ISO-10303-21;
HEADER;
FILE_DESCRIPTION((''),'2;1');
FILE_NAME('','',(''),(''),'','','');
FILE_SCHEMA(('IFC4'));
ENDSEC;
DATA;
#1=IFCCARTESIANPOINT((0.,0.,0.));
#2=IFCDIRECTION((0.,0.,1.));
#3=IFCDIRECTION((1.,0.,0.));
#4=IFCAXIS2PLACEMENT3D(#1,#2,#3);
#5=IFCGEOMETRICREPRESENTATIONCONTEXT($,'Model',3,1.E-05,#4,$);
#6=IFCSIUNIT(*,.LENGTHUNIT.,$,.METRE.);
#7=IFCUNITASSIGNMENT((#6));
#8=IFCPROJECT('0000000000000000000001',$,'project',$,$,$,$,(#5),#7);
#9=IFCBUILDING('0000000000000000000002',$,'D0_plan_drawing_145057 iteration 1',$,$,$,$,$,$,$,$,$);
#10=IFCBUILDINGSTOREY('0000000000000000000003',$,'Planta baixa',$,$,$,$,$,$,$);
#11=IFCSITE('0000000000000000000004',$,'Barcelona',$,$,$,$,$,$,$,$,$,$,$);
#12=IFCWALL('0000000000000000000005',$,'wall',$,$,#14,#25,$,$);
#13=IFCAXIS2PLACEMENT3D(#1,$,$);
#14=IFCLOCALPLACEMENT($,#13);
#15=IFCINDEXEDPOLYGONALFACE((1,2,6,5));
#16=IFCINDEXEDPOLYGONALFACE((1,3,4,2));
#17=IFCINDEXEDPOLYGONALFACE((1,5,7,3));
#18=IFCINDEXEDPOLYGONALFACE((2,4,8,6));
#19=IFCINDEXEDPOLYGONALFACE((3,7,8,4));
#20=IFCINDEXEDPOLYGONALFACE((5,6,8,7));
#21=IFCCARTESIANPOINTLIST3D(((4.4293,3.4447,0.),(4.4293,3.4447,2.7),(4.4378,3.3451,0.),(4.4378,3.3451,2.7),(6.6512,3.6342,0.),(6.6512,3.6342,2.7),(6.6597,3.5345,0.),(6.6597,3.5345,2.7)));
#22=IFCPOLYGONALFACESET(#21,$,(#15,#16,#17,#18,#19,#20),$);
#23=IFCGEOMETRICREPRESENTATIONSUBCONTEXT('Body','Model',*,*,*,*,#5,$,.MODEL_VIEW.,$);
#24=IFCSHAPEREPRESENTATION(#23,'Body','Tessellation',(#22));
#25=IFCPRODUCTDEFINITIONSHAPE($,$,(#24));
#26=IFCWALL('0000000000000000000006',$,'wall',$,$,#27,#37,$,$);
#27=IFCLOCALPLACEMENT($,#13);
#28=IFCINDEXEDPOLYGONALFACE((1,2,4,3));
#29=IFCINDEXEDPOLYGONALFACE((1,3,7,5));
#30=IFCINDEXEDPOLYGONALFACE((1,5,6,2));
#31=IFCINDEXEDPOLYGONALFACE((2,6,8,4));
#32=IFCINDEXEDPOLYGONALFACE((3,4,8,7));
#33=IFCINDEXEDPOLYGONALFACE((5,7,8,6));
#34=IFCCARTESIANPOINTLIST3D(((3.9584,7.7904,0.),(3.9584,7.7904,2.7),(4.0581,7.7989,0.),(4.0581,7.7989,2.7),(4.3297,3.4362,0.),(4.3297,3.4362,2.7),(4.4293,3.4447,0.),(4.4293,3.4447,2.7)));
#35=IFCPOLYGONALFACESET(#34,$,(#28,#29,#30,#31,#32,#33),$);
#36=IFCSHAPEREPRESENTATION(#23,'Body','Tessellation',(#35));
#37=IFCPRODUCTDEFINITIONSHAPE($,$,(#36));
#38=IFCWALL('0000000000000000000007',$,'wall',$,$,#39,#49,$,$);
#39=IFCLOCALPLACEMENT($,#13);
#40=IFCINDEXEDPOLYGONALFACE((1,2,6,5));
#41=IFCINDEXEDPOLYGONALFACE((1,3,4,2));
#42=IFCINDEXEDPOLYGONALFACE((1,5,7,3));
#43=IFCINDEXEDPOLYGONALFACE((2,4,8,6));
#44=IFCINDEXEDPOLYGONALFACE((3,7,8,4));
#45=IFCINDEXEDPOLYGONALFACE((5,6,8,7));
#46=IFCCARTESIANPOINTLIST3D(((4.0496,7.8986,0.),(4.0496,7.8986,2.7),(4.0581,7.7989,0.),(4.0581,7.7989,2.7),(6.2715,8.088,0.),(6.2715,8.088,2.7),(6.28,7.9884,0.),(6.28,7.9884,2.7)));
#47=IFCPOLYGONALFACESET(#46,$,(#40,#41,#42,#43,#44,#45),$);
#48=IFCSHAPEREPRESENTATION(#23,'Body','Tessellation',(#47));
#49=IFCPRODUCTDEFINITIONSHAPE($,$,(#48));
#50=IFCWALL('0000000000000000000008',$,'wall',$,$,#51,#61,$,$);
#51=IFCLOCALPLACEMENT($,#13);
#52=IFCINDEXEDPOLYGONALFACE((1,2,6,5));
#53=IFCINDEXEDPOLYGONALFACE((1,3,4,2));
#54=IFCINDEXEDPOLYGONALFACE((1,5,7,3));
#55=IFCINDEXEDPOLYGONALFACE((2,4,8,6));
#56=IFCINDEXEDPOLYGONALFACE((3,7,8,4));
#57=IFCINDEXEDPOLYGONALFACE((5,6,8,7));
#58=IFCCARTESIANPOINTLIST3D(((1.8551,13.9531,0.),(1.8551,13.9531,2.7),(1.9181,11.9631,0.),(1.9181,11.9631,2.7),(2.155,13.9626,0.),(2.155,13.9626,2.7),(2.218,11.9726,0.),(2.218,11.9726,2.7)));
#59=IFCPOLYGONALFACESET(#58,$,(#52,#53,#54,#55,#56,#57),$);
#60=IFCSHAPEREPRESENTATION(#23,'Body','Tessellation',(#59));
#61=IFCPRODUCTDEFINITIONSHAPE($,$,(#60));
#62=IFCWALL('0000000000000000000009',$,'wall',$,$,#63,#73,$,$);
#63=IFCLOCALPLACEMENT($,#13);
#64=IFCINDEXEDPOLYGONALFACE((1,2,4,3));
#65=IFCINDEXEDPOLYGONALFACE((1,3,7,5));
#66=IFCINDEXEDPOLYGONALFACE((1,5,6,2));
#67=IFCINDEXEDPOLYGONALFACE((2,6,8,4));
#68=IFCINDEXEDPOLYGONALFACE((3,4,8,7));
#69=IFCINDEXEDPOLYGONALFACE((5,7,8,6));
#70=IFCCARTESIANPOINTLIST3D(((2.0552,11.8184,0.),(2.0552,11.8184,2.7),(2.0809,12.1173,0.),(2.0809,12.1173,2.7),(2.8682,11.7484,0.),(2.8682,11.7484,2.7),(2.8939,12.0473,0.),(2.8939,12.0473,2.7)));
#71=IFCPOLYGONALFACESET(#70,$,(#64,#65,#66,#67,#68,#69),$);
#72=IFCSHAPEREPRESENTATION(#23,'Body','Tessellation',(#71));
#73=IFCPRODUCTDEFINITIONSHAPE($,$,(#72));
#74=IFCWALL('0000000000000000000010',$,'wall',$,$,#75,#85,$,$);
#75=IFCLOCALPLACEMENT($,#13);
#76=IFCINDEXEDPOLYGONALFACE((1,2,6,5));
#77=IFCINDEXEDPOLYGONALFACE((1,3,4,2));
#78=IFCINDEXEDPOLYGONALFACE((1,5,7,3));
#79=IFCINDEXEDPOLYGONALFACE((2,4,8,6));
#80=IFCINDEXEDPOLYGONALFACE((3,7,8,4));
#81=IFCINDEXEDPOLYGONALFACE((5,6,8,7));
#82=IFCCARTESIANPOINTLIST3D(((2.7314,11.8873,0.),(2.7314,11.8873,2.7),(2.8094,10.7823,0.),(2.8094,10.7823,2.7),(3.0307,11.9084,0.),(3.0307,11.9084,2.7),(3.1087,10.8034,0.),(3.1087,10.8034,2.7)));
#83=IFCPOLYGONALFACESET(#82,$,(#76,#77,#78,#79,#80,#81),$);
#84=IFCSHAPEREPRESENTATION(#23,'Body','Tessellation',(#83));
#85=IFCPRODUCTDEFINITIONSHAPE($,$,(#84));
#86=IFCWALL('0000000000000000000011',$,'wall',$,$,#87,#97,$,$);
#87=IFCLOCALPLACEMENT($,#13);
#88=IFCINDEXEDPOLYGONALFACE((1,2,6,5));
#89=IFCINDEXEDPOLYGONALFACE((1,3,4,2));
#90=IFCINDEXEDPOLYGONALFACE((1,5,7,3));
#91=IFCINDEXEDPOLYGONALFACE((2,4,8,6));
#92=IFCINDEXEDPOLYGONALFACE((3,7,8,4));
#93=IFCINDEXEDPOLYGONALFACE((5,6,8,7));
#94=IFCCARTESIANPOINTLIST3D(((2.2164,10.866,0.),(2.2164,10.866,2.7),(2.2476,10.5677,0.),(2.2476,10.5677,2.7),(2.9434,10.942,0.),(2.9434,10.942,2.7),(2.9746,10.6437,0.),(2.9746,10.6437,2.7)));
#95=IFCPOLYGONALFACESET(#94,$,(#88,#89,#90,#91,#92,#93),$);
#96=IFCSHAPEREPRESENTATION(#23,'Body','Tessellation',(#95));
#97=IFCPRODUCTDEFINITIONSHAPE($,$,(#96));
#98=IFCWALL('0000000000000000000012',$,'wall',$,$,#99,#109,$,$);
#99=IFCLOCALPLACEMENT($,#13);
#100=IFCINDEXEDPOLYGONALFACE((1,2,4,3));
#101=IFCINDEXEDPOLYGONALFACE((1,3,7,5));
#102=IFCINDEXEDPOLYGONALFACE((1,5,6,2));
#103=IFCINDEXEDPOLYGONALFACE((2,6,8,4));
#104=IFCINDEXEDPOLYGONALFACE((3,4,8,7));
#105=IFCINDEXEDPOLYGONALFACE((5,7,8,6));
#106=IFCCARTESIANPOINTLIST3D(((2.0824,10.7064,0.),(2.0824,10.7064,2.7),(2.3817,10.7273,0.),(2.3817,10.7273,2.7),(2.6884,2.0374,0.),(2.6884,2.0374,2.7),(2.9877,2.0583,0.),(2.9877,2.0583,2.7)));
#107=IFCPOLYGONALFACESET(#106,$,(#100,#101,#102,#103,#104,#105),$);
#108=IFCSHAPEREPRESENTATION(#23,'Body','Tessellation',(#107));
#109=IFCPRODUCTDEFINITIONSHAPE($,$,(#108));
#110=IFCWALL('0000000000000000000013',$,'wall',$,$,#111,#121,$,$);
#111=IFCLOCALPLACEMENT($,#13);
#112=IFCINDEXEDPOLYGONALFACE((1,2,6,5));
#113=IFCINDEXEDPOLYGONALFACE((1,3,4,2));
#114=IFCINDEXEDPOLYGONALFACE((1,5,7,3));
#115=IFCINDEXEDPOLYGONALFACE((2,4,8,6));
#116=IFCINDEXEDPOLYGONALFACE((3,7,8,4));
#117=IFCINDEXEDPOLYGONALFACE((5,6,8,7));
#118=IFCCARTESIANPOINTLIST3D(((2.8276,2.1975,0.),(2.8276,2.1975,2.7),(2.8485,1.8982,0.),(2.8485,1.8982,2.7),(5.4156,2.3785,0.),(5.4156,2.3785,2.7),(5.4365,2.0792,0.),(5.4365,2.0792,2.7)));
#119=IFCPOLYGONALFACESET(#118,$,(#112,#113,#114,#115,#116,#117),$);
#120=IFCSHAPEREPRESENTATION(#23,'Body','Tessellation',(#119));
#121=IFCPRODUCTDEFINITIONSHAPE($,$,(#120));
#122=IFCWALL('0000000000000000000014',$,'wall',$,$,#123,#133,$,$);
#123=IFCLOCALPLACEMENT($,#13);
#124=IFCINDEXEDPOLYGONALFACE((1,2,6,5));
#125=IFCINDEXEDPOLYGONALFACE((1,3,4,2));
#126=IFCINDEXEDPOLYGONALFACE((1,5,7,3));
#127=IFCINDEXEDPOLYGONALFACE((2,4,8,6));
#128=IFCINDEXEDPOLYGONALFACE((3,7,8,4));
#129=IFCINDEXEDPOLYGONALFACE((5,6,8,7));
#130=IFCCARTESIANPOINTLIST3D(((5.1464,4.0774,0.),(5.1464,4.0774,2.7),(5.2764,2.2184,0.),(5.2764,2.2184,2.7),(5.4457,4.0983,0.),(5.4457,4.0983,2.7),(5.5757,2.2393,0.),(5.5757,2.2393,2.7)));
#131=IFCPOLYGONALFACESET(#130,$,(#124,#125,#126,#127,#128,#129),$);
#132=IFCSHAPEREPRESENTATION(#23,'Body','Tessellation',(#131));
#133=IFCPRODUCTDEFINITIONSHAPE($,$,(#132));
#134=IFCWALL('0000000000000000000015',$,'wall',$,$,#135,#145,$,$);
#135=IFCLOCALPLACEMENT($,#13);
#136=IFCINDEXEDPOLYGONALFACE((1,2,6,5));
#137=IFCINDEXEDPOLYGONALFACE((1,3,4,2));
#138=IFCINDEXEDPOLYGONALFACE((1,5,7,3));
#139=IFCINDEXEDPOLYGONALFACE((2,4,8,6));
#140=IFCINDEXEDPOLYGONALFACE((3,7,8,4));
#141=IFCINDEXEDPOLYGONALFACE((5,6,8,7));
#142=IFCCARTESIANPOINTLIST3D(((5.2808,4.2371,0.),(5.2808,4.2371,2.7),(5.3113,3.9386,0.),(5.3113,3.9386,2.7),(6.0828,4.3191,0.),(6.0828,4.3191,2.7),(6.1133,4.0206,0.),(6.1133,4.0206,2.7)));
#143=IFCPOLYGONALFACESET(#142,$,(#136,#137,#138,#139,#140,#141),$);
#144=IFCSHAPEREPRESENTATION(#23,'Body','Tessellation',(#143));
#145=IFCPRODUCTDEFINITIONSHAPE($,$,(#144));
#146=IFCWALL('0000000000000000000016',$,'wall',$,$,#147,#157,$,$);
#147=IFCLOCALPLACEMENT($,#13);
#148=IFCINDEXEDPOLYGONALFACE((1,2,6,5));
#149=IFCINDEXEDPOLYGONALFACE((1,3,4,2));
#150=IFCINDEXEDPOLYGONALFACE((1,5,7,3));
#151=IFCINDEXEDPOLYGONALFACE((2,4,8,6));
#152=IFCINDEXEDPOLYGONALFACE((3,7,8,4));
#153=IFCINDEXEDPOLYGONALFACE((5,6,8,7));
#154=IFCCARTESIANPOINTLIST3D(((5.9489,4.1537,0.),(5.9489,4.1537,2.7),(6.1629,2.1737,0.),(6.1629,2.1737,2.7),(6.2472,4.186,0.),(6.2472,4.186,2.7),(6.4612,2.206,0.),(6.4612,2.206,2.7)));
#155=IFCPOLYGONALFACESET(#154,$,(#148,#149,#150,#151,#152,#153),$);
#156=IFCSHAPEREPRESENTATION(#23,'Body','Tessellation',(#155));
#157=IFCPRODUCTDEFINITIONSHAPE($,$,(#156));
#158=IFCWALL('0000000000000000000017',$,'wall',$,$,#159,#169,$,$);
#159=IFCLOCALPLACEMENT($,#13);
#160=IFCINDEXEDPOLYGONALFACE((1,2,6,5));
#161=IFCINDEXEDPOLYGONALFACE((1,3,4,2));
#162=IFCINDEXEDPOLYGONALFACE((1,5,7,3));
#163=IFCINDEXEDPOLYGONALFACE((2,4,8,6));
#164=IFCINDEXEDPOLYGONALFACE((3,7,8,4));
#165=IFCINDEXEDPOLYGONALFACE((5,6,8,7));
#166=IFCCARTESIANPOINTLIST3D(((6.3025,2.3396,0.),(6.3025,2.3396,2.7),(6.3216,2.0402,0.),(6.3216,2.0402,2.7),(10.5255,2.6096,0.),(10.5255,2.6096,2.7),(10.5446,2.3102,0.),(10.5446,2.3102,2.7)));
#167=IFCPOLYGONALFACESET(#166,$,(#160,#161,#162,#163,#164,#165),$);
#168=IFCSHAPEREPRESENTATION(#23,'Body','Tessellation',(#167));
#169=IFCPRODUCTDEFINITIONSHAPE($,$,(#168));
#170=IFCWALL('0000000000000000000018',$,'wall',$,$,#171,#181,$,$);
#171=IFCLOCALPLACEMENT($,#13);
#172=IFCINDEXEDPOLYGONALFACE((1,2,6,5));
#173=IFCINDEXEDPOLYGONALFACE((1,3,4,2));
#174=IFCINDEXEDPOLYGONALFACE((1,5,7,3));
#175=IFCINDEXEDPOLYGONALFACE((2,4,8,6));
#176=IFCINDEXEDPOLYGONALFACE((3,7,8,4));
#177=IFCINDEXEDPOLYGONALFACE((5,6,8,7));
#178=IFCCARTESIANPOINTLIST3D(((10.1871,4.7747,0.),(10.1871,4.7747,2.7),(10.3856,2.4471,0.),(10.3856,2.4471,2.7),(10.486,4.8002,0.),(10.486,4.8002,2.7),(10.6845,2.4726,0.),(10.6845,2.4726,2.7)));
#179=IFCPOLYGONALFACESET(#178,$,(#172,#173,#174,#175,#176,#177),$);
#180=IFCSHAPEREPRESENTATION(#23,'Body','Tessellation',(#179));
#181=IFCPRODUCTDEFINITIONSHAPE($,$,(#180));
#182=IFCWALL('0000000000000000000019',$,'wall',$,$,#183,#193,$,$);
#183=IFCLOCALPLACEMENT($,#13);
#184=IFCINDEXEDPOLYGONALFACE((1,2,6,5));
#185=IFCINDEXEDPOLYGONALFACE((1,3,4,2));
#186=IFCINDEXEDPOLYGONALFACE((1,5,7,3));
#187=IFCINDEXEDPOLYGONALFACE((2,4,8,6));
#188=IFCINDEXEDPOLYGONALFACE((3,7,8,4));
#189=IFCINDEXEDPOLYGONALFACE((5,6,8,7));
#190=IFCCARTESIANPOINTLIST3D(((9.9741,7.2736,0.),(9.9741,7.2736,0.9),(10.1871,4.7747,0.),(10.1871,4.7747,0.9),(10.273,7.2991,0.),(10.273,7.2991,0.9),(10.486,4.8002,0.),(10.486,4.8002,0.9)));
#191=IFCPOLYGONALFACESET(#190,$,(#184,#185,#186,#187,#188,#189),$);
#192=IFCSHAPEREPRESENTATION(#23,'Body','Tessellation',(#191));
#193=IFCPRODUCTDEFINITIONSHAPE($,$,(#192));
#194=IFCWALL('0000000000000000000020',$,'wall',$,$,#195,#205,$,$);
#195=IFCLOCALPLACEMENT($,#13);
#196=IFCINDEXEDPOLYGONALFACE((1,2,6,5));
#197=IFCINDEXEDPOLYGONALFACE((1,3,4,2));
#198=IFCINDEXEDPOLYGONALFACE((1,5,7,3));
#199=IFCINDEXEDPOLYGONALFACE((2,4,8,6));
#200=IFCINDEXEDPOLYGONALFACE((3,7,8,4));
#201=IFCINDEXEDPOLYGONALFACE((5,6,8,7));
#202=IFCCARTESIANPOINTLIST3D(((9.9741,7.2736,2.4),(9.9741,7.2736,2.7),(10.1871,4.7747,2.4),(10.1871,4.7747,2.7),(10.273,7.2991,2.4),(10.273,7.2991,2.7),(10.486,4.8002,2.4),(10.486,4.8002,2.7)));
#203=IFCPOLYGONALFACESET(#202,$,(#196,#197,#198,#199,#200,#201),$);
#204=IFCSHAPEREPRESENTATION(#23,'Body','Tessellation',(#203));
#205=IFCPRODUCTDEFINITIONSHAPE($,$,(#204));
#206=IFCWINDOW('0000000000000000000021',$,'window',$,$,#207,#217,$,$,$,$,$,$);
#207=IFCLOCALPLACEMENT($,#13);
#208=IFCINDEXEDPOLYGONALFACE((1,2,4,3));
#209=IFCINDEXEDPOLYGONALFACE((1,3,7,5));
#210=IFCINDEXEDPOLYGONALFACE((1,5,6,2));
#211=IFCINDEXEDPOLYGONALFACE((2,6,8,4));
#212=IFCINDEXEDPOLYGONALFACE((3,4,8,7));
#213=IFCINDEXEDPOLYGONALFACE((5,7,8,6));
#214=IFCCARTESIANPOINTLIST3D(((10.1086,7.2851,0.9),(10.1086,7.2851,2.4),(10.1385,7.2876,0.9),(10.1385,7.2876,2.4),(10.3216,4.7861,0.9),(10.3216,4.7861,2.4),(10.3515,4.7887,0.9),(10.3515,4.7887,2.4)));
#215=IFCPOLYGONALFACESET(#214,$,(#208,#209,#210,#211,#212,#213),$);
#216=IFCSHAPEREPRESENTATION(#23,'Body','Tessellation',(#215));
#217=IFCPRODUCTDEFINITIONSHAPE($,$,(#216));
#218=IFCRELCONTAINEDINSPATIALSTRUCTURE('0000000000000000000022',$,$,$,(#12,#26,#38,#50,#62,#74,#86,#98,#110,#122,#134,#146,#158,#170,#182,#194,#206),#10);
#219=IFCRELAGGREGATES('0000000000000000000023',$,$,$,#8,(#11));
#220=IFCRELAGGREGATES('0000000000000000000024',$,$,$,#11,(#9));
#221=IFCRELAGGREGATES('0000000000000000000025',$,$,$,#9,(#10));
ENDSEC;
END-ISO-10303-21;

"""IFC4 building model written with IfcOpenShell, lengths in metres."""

from ifc_helpers import new_model, si_unit, frame, origin, origin_with_axes, place, context, subcontext, project, spatial, polyline, outline, extrude, element, save


model = new_model("IFC4")

# Units and contexts
model_context = context("Model", 3, precision=1e-05, world=origin_with_axes())
body_context = subcontext(model_context, "Body", "Model", "MODEL_VIEW")
ifc_project = project(units=[si_unit("LENGTHUNIT", "METRE")], contexts=[model_context])

# Site, building, storey
site = spatial("IfcSite", under=ifc_project, Name="Barcelona")
building = spatial("IfcBuilding", under=site, Name="D0_plan_drawing_145057 iteration 1")
storey = spatial("IfcBuildingStorey", under=building, Name="Planta baixa")

# Walls
wall_1_placement = place(None, origin_with_axes())
element("IfcWall", 1, at=wall_1_placement, inside=storey, Name="wall", context=body_context, shape_type="SweptSolid", body=[
    extrude(outline(polyline([(6.6597, 3.5345), (4.4378, 3.3451), (4.4293, 3.4447), (6.6512, 3.6342), (6.6597, 3.5345)])), origin(), (0.0, 0.0, 1.0), 2.7),
])
wall_2_placement = place(None, origin_with_axes())
element("IfcWall", 2, at=wall_2_placement, inside=storey, Name="wall", context=body_context, shape_type="SweptSolid", body=[
    extrude(outline(polyline([(4.3297, 3.4362), (3.9584, 7.7904), (4.0581, 7.7989), (4.4293, 3.4447), (4.3297, 3.4362)])), origin(), (0.0, 0.0, 1.0), 2.7),
])
wall_3_placement = place(None, origin_with_axes())
element("IfcWall", 3, at=wall_3_placement, inside=storey, Name="wall", context=body_context, shape_type="SweptSolid", body=[
    extrude(outline(polyline([(4.0496, 7.8986), (6.2715, 8.088), (6.28, 7.9884), (4.0581, 7.7989), (4.0496, 7.8986)])), origin(), (0.0, 0.0, 1.0), 2.7),
])
wall_4_placement = place(None, origin_with_axes())
element("IfcWall", 4, at=wall_4_placement, inside=storey, Name="wall", context=body_context, shape_type="SweptSolid", body=[
    extrude(outline(polyline([(2.155, 13.9626), (2.218, 11.9726), (1.9181, 11.9631), (1.8551, 13.9531), (2.155, 13.9626)])), origin(), (0.0, 0.0, 1.0), 2.7),
])
wall_5_placement = place(None, origin_with_axes())
element("IfcWall", 5, at=wall_5_placement, inside=storey, Name="wall", context=body_context, shape_type="SweptSolid", body=[
    extrude(outline(polyline([(2.0809, 12.1173), (2.8939, 12.0473), (2.8682, 11.7484), (2.0552, 11.8184), (2.0809, 12.1173)])), origin(), (0.0, 0.0, 1.0), 2.7),
])
wall_6_placement = place(None, origin_with_axes())
element("IfcWall", 6, at=wall_6_placement, inside=storey, Name="wall", context=body_context, shape_type="SweptSolid", body=[
    extrude(outline(polyline([(3.0307, 11.9084), (3.1087, 10.8034), (2.8094, 10.7823), (2.7314, 11.8873), (3.0307, 11.9084)])), origin(), (0.0, 0.0, 1.0), 2.7),
])
wall_7_placement = place(None, origin_with_axes())
element("IfcWall", 7, at=wall_7_placement, inside=storey, Name="wall", context=body_context, shape_type="SweptSolid", body=[
    extrude(outline(polyline([(2.9746, 10.6437), (2.2476, 10.5677), (2.2164, 10.866), (2.9434, 10.942), (2.9746, 10.6437)])), origin(), (0.0, 0.0, 1.0), 2.7),
])
wall_8_placement = place(None, origin_with_axes())
element("IfcWall", 8, at=wall_8_placement, inside=storey, Name="wall", context=body_context, shape_type="SweptSolid", body=[
    extrude(outline(polyline([(2.3817, 10.7273), (2.9877, 2.0583), (2.6884, 2.0374), (2.0824, 10.7064), (2.3817, 10.7273)])), origin(), (0.0, 0.0, 1.0), 2.7),
])
wall_9_placement = place(None, origin_with_axes())
element("IfcWall", 9, at=wall_9_placement, inside=storey, Name="wall", context=body_context, shape_type="SweptSolid", body=[
    extrude(outline(polyline([(2.8276, 2.1975), (5.4156, 2.3785), (5.4365, 2.0792), (2.8485, 1.8982), (2.8276, 2.1975)])), origin(), (0.0, 0.0, 1.0), 2.7),
])
wall_10_placement = place(None, origin_with_axes())
element("IfcWall", 10, at=wall_10_placement, inside=storey, Name="wall", context=body_context, shape_type="SweptSolid", body=[
    extrude(outline(polyline([(5.2764, 2.2184), (5.1464, 4.0774), (5.4457, 4.0983), (5.5757, 2.2393), (5.2764, 2.2184)])), origin(), (0.0, 0.0, 1.0), 2.7),
])
wall_11_placement = place(None, origin_with_axes())
element("IfcWall", 11, at=wall_11_placement, inside=storey, Name="wall", context=body_context, shape_type="SweptSolid", body=[
    extrude(outline(polyline([(5.2808, 4.2371), (6.0828, 4.3191), (6.1133, 4.0206), (5.3113, 3.9386), (5.2808, 4.2371)])), origin(), (0.0, 0.0, 1.0), 2.7),
])
wall_12_placement = place(None, origin_with_axes())
element("IfcWall", 12, at=wall_12_placement, inside=storey, Name="wall", context=body_context, shape_type="SweptSolid", body=[
    extrude(outline(polyline([(6.2472, 4.186), (6.4612, 2.206), (6.1629, 2.1737), (5.9489, 4.1537), (6.2472, 4.186)])), origin(), (0.0, 0.0, 1.0), 2.7),
])
wall_13_placement = place(None, origin_with_axes())
element("IfcWall", 13, at=wall_13_placement, inside=storey, Name="wall", context=body_context, shape_type="SweptSolid", body=[
    extrude(outline(polyline([(6.3025, 2.3396), (10.5255, 2.6096), (10.5446, 2.3102), (6.3216, 2.0402), (6.3025, 2.3396)])), origin(), (0.0, 0.0, 1.0), 2.7),
])
wall_14_placement = place(None, origin_with_axes())
element("IfcWall", 14, at=wall_14_placement, inside=storey, Name="wall", context=body_context, shape_type="SweptSolid", body=[
    extrude(outline(polyline([(10.3856, 2.4471), (10.1871, 4.7747), (10.486, 4.8002), (10.6845, 2.4726), (10.3856, 2.4471)])), origin(), (0.0, 0.0, 1.0), 2.7),
])
wall_15_placement = place(None, origin_with_axes())
element("IfcWall", 15, at=wall_15_placement, inside=storey, Name="wall", context=body_context, shape_type="SweptSolid", body=[
    extrude(outline(polyline([(10.1871, 4.7747), (9.9741, 7.2736), (10.273, 7.2991), (10.486, 4.8002), (10.1871, 4.7747)])), origin(), (0.0, 0.0, 1.0), 0.9),
])
wall_16_placement = place(None, origin_with_axes())
element("IfcWall", 16, at=wall_16_placement, inside=storey, Name="wall", context=body_context, shape_type="SweptSolid", body=[
    extrude(outline(polyline([(10.1871, 4.7747), (9.9741, 7.2736), (10.273, 7.2991), (10.486, 4.8002), (10.1871, 4.7747)])), frame((0.0, 0.0, 2.4)), (0.0, 0.0, 1.0), 0.3),
])

# Window
window_1_placement = place(None, origin_with_axes())
element("IfcWindow", 17, at=window_1_placement, inside=storey, Name="window", context=body_context, shape_type="SweptSolid", body=[
    extrude(outline(polyline([(10.3216, 4.7861), (10.1086, 7.2851), (10.1385, 7.2876), (10.3515, 4.7887), (10.3216, 4.7861)])), frame((0.0, 0.0, 0.9)), (0.0, 0.0, 1.0), 1.5),
])

save(model, "model.ifc")
